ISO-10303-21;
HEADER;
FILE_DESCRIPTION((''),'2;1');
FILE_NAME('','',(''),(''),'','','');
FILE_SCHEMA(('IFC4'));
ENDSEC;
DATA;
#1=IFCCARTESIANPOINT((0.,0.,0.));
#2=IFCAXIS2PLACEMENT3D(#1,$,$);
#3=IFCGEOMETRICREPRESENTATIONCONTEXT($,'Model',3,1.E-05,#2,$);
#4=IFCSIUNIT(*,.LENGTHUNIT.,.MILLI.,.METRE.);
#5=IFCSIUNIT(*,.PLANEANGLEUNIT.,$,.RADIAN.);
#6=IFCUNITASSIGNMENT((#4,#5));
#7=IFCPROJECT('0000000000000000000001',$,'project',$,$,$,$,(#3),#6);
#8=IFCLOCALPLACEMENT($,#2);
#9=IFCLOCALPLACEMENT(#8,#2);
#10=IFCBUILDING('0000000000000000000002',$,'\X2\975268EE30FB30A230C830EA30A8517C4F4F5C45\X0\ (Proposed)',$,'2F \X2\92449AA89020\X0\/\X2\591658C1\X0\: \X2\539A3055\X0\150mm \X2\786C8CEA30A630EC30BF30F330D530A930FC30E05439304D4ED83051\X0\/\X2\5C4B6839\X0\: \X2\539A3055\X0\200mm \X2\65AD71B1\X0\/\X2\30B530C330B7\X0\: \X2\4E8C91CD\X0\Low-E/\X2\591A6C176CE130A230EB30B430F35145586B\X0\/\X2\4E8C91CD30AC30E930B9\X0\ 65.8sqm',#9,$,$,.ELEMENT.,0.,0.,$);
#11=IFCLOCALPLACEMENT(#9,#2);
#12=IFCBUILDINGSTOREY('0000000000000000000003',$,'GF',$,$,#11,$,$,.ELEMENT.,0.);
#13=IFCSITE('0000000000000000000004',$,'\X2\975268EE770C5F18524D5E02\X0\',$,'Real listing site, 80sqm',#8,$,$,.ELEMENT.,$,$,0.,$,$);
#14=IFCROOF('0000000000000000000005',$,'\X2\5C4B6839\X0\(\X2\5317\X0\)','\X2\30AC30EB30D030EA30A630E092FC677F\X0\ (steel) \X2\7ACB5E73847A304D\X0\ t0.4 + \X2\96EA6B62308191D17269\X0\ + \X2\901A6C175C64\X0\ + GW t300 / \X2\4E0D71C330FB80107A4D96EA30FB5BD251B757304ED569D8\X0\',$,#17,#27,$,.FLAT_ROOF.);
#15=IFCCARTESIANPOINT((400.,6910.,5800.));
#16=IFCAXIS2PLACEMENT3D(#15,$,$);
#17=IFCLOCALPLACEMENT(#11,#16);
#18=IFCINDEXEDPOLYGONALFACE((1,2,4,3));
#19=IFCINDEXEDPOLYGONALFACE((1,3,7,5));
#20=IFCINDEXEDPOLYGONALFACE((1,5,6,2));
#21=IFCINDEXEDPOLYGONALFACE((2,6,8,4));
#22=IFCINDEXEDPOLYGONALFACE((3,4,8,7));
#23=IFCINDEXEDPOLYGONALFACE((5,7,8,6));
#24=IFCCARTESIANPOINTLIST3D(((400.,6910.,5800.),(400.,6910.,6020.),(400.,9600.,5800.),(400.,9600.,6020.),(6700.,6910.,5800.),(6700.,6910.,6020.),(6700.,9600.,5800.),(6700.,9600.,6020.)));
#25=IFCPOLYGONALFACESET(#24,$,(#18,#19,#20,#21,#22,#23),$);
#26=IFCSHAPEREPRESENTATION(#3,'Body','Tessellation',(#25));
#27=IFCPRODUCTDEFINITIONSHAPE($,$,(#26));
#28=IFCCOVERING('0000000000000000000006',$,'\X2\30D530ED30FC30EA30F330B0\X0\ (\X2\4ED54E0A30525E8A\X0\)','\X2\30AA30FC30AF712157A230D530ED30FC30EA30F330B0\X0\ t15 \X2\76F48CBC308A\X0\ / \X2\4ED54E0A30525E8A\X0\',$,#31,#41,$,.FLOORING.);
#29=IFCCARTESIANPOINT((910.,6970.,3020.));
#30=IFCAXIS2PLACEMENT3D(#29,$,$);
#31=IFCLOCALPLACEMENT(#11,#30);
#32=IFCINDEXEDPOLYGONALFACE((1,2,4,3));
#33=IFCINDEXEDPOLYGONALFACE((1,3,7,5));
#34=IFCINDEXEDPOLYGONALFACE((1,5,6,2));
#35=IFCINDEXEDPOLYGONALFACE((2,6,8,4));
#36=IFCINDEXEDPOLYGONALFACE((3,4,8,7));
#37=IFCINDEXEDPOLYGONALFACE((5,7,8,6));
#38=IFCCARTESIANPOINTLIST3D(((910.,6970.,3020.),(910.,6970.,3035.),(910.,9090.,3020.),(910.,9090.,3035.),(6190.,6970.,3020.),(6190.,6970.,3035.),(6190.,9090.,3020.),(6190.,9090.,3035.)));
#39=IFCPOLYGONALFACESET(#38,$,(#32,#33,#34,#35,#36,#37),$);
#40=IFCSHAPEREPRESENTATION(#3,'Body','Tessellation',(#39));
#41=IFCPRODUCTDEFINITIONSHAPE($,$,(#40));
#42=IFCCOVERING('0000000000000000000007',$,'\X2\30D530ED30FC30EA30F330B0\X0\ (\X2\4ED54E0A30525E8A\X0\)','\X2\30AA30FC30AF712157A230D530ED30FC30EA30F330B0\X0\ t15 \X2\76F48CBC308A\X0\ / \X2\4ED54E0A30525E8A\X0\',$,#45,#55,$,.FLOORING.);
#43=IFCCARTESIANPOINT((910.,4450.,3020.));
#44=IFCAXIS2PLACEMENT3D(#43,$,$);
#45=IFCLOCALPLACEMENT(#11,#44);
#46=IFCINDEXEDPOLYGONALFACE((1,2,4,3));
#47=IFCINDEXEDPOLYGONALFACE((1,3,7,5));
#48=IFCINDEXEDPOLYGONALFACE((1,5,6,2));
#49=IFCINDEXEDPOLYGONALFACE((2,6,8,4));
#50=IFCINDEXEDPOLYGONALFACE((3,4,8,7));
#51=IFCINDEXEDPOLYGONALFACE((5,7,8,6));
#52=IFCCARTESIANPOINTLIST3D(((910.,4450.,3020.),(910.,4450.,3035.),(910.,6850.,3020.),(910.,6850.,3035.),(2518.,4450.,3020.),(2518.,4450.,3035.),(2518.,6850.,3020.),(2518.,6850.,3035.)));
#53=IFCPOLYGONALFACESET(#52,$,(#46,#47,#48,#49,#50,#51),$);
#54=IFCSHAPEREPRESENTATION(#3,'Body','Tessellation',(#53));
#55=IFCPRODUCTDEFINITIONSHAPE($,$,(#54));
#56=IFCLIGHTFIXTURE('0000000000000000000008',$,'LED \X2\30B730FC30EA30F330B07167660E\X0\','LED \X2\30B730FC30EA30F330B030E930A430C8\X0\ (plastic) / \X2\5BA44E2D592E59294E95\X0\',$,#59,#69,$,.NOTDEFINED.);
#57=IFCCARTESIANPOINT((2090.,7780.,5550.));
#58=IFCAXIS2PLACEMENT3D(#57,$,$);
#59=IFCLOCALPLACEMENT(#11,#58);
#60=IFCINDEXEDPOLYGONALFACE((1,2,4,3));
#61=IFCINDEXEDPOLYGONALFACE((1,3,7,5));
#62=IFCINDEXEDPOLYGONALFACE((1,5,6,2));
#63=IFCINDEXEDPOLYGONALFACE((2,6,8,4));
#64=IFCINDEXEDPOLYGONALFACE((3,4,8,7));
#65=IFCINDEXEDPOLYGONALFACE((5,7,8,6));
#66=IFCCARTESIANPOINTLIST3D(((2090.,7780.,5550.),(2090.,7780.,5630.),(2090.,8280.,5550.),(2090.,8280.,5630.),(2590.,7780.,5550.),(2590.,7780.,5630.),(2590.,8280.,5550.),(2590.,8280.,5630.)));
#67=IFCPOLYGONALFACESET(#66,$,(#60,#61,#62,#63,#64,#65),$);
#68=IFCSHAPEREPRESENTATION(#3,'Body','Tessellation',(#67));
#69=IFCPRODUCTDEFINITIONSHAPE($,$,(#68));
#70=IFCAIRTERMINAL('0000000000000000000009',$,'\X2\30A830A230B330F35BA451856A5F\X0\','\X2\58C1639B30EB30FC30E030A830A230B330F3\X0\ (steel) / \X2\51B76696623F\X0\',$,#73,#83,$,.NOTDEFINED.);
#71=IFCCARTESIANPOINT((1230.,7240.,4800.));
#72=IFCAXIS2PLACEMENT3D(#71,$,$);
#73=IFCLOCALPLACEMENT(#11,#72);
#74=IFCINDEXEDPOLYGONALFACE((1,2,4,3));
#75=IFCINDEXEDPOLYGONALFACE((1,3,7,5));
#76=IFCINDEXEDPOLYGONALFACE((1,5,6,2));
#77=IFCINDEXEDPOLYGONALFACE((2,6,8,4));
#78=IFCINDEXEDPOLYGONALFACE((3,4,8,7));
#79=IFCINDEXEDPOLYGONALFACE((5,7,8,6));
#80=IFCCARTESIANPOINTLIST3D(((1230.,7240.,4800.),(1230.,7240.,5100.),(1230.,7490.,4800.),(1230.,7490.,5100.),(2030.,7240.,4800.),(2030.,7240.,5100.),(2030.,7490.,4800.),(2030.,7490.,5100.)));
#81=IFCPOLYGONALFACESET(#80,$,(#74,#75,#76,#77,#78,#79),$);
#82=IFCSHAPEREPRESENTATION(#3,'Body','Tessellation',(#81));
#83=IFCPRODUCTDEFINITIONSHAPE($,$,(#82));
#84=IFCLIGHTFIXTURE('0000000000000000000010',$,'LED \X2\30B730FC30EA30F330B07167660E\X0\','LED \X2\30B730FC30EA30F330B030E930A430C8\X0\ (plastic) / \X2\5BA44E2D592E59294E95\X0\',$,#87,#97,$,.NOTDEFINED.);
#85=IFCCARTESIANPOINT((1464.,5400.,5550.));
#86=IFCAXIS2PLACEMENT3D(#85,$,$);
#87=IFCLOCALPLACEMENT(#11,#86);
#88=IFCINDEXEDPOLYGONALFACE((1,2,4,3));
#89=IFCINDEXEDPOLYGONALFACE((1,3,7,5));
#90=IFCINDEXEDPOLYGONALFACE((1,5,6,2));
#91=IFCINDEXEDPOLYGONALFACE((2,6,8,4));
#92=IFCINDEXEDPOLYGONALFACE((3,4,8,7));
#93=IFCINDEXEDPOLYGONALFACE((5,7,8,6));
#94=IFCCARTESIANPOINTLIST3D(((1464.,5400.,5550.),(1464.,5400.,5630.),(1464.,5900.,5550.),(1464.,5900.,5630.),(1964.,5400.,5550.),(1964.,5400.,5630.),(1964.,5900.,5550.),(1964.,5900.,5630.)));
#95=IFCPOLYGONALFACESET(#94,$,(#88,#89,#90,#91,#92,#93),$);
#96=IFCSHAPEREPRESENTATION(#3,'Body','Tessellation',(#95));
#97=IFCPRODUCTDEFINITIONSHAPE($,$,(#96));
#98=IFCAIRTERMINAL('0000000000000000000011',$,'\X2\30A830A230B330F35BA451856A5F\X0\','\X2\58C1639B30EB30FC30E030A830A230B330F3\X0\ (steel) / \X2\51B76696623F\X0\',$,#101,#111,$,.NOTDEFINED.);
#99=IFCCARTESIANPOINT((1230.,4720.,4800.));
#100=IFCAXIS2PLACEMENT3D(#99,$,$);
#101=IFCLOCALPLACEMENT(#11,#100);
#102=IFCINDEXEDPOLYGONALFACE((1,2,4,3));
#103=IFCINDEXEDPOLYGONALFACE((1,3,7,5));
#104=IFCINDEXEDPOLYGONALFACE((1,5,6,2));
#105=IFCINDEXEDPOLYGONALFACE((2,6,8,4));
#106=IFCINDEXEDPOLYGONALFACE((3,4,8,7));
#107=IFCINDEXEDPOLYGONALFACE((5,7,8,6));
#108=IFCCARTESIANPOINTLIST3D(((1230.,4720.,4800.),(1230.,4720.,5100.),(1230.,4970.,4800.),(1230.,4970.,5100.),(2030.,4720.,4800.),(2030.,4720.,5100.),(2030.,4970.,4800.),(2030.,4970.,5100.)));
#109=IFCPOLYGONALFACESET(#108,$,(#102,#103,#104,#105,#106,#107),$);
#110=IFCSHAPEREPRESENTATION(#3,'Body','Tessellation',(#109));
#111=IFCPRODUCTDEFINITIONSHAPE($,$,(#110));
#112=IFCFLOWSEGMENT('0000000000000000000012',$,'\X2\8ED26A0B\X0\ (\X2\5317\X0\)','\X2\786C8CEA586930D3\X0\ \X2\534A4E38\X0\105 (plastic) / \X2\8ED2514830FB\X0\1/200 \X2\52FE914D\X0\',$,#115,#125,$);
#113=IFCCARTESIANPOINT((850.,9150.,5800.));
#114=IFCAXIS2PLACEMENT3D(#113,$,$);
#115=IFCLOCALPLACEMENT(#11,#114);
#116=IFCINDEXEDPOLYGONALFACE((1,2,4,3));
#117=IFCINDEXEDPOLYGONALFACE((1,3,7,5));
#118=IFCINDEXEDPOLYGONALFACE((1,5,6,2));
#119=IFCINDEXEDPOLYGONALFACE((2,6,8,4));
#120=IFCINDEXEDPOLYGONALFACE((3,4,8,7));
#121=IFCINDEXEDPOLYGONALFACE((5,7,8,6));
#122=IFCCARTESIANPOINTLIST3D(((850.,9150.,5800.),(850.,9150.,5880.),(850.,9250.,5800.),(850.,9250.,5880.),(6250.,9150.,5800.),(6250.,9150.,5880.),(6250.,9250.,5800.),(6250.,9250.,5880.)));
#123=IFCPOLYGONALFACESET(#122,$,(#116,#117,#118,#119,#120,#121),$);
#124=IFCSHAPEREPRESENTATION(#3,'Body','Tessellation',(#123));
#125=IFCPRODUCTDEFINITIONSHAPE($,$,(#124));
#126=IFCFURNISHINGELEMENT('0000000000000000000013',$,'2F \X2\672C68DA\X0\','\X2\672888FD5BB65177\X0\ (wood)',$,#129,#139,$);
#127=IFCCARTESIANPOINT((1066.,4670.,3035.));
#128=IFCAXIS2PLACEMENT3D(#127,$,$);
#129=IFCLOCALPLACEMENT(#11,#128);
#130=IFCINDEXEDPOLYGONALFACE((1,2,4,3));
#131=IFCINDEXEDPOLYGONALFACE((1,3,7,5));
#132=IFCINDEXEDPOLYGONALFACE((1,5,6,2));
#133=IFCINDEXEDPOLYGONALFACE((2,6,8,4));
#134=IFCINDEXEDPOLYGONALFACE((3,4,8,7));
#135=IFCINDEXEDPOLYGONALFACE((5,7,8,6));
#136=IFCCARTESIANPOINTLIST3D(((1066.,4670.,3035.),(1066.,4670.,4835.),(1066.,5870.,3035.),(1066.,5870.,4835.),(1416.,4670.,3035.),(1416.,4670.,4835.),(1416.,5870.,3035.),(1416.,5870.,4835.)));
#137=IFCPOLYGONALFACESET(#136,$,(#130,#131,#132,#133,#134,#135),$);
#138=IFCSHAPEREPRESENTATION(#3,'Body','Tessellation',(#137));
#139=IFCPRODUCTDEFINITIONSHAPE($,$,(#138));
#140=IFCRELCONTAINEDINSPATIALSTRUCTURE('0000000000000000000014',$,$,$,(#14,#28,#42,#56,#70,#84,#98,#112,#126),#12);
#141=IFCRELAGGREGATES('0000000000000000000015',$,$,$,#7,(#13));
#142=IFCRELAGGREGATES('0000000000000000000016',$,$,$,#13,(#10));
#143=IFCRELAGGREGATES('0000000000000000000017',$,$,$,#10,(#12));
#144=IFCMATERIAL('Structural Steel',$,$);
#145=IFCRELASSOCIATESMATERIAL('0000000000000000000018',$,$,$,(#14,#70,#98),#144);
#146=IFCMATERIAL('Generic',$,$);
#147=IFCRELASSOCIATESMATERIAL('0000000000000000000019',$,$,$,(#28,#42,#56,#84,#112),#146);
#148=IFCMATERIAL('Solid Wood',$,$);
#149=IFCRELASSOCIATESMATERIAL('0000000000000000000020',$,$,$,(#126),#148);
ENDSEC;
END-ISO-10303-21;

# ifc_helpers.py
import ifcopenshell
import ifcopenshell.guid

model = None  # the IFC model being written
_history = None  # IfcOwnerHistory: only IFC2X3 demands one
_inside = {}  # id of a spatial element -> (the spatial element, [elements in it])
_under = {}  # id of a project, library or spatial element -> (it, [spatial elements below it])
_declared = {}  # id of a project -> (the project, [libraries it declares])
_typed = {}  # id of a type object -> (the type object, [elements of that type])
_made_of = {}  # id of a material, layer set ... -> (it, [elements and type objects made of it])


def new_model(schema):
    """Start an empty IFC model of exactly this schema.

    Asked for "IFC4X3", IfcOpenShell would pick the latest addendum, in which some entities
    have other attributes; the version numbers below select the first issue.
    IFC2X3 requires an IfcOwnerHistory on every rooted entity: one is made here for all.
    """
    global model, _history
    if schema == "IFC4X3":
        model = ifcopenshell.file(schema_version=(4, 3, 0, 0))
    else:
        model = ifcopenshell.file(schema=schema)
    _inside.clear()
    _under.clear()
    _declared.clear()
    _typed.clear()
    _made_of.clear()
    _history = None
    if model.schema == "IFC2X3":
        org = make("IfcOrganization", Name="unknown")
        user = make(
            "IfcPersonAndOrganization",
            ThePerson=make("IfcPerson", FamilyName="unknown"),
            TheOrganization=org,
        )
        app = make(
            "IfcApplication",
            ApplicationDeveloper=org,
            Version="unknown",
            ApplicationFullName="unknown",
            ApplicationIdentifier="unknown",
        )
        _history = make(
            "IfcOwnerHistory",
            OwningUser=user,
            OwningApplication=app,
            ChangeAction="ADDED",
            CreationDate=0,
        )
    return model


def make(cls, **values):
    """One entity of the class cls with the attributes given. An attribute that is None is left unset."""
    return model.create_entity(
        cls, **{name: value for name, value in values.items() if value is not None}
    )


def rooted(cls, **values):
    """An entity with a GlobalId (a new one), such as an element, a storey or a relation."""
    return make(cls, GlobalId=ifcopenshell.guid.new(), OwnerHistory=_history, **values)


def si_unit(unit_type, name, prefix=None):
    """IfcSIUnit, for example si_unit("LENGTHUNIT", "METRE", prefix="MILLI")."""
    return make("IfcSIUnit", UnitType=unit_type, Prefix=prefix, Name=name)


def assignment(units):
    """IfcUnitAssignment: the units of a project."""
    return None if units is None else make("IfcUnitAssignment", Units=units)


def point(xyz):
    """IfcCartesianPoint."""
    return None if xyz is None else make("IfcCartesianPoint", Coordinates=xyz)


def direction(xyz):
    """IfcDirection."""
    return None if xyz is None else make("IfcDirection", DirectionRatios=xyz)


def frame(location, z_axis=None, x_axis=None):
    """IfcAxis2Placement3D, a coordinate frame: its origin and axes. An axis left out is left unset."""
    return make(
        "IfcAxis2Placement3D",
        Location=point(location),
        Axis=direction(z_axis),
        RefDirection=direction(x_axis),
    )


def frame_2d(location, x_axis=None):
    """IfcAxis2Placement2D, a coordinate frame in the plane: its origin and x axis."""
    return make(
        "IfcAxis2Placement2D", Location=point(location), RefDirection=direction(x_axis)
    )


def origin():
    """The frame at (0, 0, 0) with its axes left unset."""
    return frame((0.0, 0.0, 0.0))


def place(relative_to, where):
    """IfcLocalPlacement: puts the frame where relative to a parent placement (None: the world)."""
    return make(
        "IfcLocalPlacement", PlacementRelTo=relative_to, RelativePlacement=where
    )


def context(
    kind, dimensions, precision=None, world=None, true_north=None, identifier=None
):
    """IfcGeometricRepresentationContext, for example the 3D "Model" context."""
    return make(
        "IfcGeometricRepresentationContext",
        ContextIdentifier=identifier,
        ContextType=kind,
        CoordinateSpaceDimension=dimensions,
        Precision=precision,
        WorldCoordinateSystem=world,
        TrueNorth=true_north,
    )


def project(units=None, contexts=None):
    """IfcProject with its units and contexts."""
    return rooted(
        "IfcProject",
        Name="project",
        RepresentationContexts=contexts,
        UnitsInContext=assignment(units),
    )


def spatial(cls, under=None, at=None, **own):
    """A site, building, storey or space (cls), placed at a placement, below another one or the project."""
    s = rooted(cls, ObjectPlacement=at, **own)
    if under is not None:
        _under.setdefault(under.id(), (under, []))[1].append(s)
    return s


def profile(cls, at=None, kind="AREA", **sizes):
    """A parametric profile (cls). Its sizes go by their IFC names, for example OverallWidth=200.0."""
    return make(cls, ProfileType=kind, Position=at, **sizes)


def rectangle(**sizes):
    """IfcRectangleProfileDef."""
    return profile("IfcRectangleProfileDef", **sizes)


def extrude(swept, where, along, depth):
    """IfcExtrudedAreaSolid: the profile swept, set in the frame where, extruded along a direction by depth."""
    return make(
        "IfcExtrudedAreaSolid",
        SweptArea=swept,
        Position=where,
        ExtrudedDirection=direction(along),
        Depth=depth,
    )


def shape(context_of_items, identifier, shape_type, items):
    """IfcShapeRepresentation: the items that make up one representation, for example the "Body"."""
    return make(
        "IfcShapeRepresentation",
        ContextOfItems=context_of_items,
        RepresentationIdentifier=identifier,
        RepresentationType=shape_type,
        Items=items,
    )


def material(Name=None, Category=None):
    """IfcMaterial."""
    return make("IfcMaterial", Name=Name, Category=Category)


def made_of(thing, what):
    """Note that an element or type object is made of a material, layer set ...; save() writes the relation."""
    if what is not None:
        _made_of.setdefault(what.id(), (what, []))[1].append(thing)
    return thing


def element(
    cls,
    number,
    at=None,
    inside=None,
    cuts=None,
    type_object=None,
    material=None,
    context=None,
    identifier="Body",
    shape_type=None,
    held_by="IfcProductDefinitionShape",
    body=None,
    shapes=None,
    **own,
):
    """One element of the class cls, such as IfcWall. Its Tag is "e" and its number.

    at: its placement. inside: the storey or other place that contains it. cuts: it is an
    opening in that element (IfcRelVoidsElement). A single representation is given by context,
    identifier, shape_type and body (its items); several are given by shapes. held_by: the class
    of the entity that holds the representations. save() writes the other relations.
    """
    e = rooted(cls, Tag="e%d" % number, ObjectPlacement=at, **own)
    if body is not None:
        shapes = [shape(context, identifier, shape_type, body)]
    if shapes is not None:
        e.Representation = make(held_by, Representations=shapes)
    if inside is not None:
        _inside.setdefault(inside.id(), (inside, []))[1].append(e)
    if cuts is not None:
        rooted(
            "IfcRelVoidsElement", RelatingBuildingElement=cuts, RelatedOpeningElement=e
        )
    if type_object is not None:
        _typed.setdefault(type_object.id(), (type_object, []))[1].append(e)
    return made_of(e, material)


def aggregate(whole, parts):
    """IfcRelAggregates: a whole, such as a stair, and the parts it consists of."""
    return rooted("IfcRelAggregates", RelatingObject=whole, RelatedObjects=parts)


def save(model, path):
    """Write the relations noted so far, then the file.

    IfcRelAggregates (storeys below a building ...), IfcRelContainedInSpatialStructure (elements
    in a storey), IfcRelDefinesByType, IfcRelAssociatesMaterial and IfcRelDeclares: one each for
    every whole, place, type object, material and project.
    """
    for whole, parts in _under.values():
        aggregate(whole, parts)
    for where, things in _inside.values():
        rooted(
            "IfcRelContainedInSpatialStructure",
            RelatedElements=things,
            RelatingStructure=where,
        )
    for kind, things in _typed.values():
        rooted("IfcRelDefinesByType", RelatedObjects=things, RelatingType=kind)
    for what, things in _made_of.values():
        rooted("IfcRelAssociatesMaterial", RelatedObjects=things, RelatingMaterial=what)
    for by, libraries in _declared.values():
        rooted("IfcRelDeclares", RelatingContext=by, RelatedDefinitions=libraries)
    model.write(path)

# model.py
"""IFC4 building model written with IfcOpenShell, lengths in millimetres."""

from ifc_helpers import new_model, si_unit, frame, frame_2d, origin, place, context, project, spatial, rectangle, extrude, material, element, save


model = new_model("IFC4")

# Units and contexts
model_context = context("Model", 3, precision=1e-05, world=origin())
ifc_project = project(units=[si_unit("LENGTHUNIT", "METRE", prefix="MILLI"), si_unit("PLANEANGLEUNIT", "RADIAN")], contexts=[model_context])

# Site, building, storey
site_placement = place(None, origin())
site = spatial("IfcSite", under=ifc_project, at=site_placement, Name="青森県弘前市", ObjectType="Real listing site, 80sqm", CompositionType="ELEMENT", RefElevation=0.0)
building_placement = place(site_placement, origin())
building = spatial("IfcBuilding", under=site, at=building_placement, Name="青森・アトリエ兼住居 (Proposed)", ObjectType="2F 鉄骨造/外壁: 厚さ150mm 硬質ウレタンフォーム吹き付け/屋根: 厚さ200mm 断熱/サッシ: 二重Low-E/多気泡アルゴン充填/二重ガラス 65.8sqm", CompositionType="ELEMENT", ElevationOfRefHeight=0.0, ElevationOfTerrain=0.0)
storey_placement = place(building_placement, origin())
storey = spatial("IfcBuildingStorey", under=building, at=storey_placement, Name="GF", CompositionType="ELEMENT", Elevation=0.0)

# Shared definitions
ifc_material_1 = material(Name="Solid Wood")

# Roof
ifc_material_2 = material(Name="Structural Steel")
for number, where, name in (
    (1, (400.0, 6910.0, 5800.0), "屋根(北)"),
):
    element("IfcRoof", number, at=place(storey_placement, frame(where)), inside=storey, material=ifc_material_2, Name=name, Description="ガルバリウム鋼板 (steel) 立平葺き t0.4 + 雪止め金物 + 通気層 + GW t300 / 不燃・耐積雪・寒冷地仕様", PredefinedType="FLAT_ROOF", context=model_context, shape_type="SweptSolid", body=[
        extrude(rectangle(XDim=6300.0, YDim=2690.0, at=frame_2d((3150.0, 1345.0))), frame((400.0, 6910.0, 5800.0)), (0.0, 0.0, 1.0), 220.0),
    ])

# Coverings
ifc_material_3 = material(Name="Generic")
covering_1_placement = place(storey_placement, frame((910.0, 6970.0, 3020.0)))
element("IfcCovering", 2, at=covering_1_placement, inside=storey, material=ifc_material_3, Name="フローリング (仕上げ床)", Description="オーク無垢フローリング t15 直貼り / 仕上げ床", PredefinedType="FLOORING", context=model_context, shape_type="SweptSolid", body=[
    extrude(rectangle(XDim=5280.0, YDim=2120.0, at=frame_2d((2640.0, 1060.0))), frame((910.0, 6970.0, 3020.0)), (0.0, 0.0, 1.0), 15.0),
])
covering_2_placement = place(storey_placement, frame((910.0, 4450.0, 3020.0)))
element("IfcCovering", 3, at=covering_2_placement, inside=storey, material=ifc_material_3, Name="フローリング (仕上げ床)", Description="オーク無垢フローリング t15 直貼り / 仕上げ床", PredefinedType="FLOORING", context=model_context, shape_type="SweptSolid", body=[
    extrude(rectangle(XDim=1608.0, YDim=2400.0, at=frame_2d((804.0, 1200.0))), frame((910.0, 4450.0, 3020.0)), (0.0, 0.0, 1.0), 15.0),
])

# Light fixture
light_fixture_1_placement = place(storey_placement, frame((2090.0, 7780.0, 5550.0)))
element("IfcLightFixture", 4, at=light_fixture_1_placement, inside=storey, material=ifc_material_3, Name="LED シーリング照明", Description="LED シーリングライト (plastic) / 室中央天井", PredefinedType="NOTDEFINED", context=model_context, shape_type="SweptSolid", body=[
    extrude(rectangle(XDim=500.0, YDim=500.0, at=frame_2d((250.0, 250.0))), frame((2090.0, 7780.0, 5550.0)), (0.0, 0.0, 1.0), 80.0),
])

# Air terminal
air_terminal_1_placement = place(storey_placement, frame((1230.0, 7240.0, 4800.0)))
element("IfcAirTerminal", 5, at=air_terminal_1_placement, inside=storey, material=ifc_material_2, Name="エアコン室内機", Description="壁掛ルームエアコン (steel) / 冷暖房", PredefinedType="NOTDEFINED", context=model_context, shape_type="SweptSolid", body=[
    extrude(rectangle(XDim=800.0, YDim=250.0, at=frame_2d((400.0, 125.0))), frame((1230.0, 7240.0, 4800.0)), (0.0, 0.0, 1.0), 300.0),
])

# Light fixture
light_fixture_2_placement = place(storey_placement, frame((1464.0, 5400.0, 5550.0)))
element("IfcLightFixture", 6, at=light_fixture_2_placement, inside=storey, material=ifc_material_3, Name="LED シーリング照明", Description="LED シーリングライト (plastic) / 室中央天井", PredefinedType="NOTDEFINED", context=model_context, shape_type="SweptSolid", body=[
    extrude(rectangle(XDim=500.0, YDim=500.0, at=frame_2d((250.0, 250.0))), frame((1464.0, 5400.0, 5550.0)), (0.0, 0.0, 1.0), 80.0),
])

# Air terminal
air_terminal_2_placement = place(storey_placement, frame((1230.0, 4720.0, 4800.0)))
element("IfcAirTerminal", 7, at=air_terminal_2_placement, inside=storey, material=ifc_material_2, Name="エアコン室内機", Description="壁掛ルームエアコン (steel) / 冷暖房", PredefinedType="NOTDEFINED", context=model_context, shape_type="SweptSolid", body=[
    extrude(rectangle(XDim=800.0, YDim=250.0, at=frame_2d((400.0, 125.0))), frame((1230.0, 4720.0, 4800.0)), (0.0, 0.0, 1.0), 300.0),
])

# Flow segment
flow_segment_placement = place(storey_placement, frame((850.0, 9150.0, 5800.0)))
element("IfcFlowSegment", 8, at=flow_segment_placement, inside=storey, material=ifc_material_3, Name="軒樋 (北)", Description="硬質塩ビ 半丸105 (plastic) / 軒先・1/200 勾配", context=model_context, shape_type="SweptSolid", body=[
    extrude(rectangle(XDim=5400.0, YDim=100.0, at=frame_2d((2700.0, 50.0))), frame((850.0, 9150.0, 5800.0)), (0.0, 0.0, 1.0), 80.0),
])

# Furnishing element
furnishing_placement = place(storey_placement, frame((1066.0, 4670.0, 3035.0)))
element("IfcFurnishingElement", 9, at=furnishing_placement, inside=storey, material=ifc_material_1, Name="2F 本棚", Description="木製家具 (wood)", context=model_context, shape_type="SweptSolid", body=[
    extrude(rectangle(XDim=350.0, YDim=1200.0, at=frame_2d((175.0, 600.0))), frame((1066.0, 4670.0, 3035.0)), (0.0, 0.0, 1.0), 1800.0),
])

save(model, "model.ifc")
